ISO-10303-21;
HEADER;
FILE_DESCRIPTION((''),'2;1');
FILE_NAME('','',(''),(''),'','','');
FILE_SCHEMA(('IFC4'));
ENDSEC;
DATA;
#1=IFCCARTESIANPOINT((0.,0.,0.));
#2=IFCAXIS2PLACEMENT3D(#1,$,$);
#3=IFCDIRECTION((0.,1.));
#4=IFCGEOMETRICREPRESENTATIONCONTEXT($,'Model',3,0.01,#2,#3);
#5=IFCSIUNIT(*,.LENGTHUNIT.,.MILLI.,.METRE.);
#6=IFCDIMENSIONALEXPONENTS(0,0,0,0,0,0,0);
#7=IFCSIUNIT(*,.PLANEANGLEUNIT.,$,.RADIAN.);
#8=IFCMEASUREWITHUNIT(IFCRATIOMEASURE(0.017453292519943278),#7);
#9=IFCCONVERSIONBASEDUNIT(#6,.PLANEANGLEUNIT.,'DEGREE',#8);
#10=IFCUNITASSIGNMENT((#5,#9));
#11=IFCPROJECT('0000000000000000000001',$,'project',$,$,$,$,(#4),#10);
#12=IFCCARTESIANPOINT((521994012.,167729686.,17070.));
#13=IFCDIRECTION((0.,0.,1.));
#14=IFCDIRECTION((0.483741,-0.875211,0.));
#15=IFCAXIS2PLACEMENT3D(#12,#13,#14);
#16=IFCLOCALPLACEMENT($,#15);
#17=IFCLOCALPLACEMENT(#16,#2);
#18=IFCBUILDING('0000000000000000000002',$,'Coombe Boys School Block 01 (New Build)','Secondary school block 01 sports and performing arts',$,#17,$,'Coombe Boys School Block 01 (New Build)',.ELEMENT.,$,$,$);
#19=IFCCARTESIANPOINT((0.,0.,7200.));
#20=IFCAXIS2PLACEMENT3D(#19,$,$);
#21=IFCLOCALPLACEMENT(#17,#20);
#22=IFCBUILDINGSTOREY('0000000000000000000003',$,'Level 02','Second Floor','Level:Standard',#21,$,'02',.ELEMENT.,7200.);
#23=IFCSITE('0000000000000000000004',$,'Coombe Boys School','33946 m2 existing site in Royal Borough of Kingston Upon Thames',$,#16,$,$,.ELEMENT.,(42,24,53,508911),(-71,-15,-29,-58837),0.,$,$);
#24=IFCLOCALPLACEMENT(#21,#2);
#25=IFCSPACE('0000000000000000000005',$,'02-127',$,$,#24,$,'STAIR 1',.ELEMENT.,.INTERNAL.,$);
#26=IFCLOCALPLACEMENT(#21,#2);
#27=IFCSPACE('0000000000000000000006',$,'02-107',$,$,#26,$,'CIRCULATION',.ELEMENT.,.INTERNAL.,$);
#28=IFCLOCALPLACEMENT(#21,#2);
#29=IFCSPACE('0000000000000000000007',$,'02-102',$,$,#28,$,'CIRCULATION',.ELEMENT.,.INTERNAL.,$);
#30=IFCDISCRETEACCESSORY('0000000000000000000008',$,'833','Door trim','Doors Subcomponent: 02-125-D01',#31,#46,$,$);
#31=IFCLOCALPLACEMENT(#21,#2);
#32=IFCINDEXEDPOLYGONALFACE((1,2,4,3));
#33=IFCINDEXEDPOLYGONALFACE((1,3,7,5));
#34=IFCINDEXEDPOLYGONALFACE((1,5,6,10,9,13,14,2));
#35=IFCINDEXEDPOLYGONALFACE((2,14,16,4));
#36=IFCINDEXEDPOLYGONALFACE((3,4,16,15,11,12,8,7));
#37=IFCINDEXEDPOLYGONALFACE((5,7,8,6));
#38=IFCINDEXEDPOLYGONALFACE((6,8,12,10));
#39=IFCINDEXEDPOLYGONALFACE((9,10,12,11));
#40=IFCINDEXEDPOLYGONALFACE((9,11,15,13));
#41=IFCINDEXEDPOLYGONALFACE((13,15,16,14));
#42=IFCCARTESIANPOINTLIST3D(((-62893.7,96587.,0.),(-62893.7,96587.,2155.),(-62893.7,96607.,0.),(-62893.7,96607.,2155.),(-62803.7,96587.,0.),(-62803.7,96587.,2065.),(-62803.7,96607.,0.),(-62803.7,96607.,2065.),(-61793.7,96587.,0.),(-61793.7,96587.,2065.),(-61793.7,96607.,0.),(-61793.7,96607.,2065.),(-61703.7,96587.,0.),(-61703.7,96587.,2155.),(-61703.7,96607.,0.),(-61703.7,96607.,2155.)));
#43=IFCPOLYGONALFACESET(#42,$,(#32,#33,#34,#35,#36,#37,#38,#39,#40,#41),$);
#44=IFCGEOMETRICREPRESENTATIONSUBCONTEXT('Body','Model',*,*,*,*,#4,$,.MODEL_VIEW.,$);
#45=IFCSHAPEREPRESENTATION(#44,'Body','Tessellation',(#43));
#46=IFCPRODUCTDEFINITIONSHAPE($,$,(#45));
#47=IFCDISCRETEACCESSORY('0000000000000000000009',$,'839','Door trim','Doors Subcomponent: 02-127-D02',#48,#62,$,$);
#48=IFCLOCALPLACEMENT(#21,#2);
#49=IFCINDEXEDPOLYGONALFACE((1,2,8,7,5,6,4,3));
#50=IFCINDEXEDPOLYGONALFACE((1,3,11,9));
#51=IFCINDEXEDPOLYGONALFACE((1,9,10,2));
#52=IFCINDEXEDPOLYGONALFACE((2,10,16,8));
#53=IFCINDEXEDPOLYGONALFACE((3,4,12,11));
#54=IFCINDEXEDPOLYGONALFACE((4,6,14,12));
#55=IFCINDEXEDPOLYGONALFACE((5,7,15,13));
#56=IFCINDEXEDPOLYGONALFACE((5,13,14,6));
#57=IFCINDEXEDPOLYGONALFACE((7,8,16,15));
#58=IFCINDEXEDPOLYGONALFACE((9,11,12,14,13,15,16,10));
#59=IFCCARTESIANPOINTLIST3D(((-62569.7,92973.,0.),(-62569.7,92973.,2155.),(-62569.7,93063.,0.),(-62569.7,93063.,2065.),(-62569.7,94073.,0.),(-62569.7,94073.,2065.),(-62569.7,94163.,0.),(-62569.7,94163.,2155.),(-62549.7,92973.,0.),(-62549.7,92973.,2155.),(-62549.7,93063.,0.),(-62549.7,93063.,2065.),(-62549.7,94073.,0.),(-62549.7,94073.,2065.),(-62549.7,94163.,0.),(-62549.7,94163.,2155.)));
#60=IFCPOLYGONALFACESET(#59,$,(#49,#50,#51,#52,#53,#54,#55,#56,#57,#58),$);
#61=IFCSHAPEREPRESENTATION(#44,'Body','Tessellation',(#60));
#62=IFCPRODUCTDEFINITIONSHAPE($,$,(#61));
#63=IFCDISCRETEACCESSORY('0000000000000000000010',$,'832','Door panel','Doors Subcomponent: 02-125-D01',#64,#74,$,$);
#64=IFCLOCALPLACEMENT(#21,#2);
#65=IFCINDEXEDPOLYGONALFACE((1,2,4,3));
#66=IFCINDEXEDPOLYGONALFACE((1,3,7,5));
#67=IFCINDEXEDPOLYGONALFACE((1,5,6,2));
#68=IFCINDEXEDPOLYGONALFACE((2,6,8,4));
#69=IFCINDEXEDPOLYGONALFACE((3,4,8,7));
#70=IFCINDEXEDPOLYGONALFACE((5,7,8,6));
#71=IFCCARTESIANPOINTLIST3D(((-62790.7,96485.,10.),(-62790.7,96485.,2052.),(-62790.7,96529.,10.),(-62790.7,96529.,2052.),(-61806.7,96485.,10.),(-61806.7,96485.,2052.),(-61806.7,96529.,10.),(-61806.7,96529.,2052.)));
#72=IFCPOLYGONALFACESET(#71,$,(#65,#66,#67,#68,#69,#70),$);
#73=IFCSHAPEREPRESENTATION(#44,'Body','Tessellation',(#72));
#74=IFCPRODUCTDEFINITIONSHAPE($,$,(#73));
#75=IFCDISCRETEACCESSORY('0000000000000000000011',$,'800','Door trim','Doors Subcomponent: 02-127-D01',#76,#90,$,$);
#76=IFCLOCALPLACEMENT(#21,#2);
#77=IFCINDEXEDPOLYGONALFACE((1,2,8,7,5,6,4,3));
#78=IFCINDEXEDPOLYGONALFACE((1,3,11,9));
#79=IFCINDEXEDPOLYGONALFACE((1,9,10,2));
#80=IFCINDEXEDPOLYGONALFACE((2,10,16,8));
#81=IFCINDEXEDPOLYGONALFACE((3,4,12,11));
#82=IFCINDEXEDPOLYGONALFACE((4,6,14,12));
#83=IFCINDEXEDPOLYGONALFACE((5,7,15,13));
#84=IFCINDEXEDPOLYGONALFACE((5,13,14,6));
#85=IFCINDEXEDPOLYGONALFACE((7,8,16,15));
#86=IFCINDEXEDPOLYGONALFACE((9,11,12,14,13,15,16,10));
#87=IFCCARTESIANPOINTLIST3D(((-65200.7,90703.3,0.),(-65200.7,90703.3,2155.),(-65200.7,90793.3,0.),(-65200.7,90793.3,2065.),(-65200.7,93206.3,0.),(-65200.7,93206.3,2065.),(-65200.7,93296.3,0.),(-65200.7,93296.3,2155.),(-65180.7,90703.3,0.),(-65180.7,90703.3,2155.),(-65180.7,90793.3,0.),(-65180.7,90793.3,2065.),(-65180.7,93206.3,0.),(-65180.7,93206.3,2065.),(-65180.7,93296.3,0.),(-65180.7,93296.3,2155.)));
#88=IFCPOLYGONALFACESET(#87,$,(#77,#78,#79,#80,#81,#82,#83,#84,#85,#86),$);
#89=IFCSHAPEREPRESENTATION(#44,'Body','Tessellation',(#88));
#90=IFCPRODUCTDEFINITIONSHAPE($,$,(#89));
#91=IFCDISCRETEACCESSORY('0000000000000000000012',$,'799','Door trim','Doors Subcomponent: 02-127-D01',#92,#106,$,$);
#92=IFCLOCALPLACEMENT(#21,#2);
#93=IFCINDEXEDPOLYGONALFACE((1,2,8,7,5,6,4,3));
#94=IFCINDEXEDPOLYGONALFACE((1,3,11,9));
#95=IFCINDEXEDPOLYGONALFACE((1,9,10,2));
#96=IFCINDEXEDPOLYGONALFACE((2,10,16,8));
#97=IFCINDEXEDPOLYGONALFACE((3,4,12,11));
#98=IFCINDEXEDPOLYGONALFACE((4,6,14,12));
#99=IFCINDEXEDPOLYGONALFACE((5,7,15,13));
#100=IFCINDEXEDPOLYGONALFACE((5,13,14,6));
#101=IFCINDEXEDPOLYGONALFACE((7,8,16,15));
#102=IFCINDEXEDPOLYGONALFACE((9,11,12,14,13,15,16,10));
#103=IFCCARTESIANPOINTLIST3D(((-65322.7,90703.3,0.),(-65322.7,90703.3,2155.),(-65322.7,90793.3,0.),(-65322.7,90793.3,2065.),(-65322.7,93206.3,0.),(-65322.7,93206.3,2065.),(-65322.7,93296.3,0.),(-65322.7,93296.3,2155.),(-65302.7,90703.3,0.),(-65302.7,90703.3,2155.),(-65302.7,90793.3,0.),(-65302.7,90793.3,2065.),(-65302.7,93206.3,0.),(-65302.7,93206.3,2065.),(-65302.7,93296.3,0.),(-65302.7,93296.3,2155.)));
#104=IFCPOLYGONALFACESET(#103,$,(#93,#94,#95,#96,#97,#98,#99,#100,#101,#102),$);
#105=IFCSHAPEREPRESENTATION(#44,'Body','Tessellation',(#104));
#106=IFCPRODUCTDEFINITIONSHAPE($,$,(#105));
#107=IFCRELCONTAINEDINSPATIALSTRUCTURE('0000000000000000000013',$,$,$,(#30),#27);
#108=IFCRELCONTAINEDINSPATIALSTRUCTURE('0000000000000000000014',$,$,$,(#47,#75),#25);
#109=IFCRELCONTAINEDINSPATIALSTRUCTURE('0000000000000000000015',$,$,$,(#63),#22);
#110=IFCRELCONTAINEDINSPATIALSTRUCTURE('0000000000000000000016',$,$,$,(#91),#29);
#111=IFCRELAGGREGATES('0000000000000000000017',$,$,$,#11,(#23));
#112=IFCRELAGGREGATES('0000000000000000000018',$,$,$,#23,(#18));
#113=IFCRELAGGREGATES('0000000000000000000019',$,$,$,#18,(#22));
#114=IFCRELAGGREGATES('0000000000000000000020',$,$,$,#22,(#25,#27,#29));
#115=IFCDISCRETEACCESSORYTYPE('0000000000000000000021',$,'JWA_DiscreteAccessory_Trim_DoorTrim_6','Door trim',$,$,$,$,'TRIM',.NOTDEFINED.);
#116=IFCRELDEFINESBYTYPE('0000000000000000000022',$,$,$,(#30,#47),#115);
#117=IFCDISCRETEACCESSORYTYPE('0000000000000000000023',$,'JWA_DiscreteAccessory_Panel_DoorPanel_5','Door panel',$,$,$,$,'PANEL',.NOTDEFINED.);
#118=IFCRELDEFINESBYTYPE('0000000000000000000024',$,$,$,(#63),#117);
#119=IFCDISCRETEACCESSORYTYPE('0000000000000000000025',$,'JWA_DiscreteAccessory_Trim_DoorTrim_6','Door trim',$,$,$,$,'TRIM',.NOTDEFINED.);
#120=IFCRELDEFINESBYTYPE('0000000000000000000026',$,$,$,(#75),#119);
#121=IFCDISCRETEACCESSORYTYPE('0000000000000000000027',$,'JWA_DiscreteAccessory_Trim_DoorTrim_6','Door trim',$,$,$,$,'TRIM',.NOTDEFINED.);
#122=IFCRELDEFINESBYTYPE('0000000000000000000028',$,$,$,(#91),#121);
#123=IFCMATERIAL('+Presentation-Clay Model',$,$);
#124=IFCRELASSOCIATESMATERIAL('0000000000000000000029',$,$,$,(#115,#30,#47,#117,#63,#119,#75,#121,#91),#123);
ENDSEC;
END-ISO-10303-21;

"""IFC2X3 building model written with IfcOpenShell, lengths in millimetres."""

from ifc_helpers import new_model, entity, si_unit, converted_unit, direction, frame, origin, origin_2d_with_axis, place, context, subcontext, project, spatial, polyline, rectangle, outline, extrude, source, transform, mapped, material, type_object, type_shapes, element, save


model = new_model("IFC2X3")

# Units and contexts
model_context = context("Model", 3, precision=0.01, world=origin(), true_north=direction((0.0, 1.0)))
body_context = subcontext(model_context, "Body", "Model", "MODEL_VIEW")
ifc_project = project(units=[si_unit("LENGTHUNIT", "METRE", prefix="MILLI"), converted_unit("PLANEANGLEUNIT", "DEGREE", entity("IfcRatioMeasure", 0.017453292519943278), si_unit("PLANEANGLEUNIT", "RADIAN"), dimensions=[0, 0, 0, 0, 0, 0, 0])], contexts=[model_context])

# Site, building, storey
site_placement = place(None, frame((521994012.0, 167729686.0, 17070.0), z_axis=(0.0, 0.0, 1.0), x_axis=(0.483741, -0.875211, 0.0)))
site = spatial("IfcSite", under=ifc_project, at=site_placement, Name="Coombe Boys School", Description="33946 m2 existing site in Royal Borough of Kingston Upon Thames", CompositionType="ELEMENT", RefLatitude=(42, 24, 53, 508911), RefLongitude=(-71, -15, -29, -58837), RefElevation=0.0)
building_placement = place(site_placement, origin())
building = spatial("IfcBuilding", under=site, at=building_placement, Name="Coombe Boys School Block 01 (New Build)", Description="Secondary school block 01 sports and performing arts", LongName="Coombe Boys School Block 01 (New Build)", CompositionType="ELEMENT")
storey_placement = place(building_placement, frame((0.0, 0.0, 7200.0)))
storey = spatial("IfcBuildingStorey", under=building, at=storey_placement, Name="Level 02", Description="Second Floor", ObjectType="Level:Standard", LongName="02", CompositionType="ELEMENT", Elevation=7200.0)

# Shared definitions
ifc_material_1 = material(Name="+Presentation-Clay Model")

# Shared definitions
space_1_placement = place(storey_placement, origin())
space_1 = spatial("IfcSpace", under=storey, at=space_1_placement, Name="02-127", LongName="STAIR 1", CompositionType="ELEMENT", InteriorOrExteriorSpace="INTERNAL")

# Shared definitions
space_2_placement = place(storey_placement, origin())
space_2 = spatial("IfcSpace", under=storey, at=space_2_placement, Name="02-107", LongName="CIRCULATION", CompositionType="ELEMENT", InteriorOrExteriorSpace="INTERNAL")

# Discrete accessories
discrete_accessory_type_1 = type_object("IfcDiscreteAccessoryType", Name="JWA_DiscreteAccessory_Trim_DoorTrim_6", Description="Door trim", ElementType="TRIM", material=ifc_material_1)
shared_shape_1 = source(origin(), body_context, "Body", "SweptSolid", [
    extrude(outline(polyline([(505.0, -1055.0), (595.0, -1055.0), (595.0, 1100.0), (-595.0, 1100.0), (-595.0, -1055.0), (-505.0, -1055.0), (-505.0, 1010.0), (505.0, 1010.0), (505.0, -1055.0)])), frame((0.0, 0.0, 1055.0), z_axis=(0.0, 1.0, 0.0), x_axis=(-1.0, 0.0, 0.0)), (0.0, 0.0, 1.0), 20.0),
])
type_shapes(discrete_accessory_type_1, [shared_shape_1])
discrete_accessory_1_placement = place(space_2_placement, frame((-62298.7, 96587.0, 0.0)))
element("IfcDiscreteAccessory", 1, at=discrete_accessory_1_placement, inside=space_2, type_object=discrete_accessory_type_1, material=ifc_material_1, Name="833", Description="Door trim", ObjectType="Doors Subcomponent: 02-125-D01", context=body_context, shape_type="MappedRepresentation", body=[
    mapped(shared_shape_1, transform((0.0, 0.0, 0.0), scale=1.0)),
])
discrete_accessory_2_placement = place(space_1_placement, frame((-62549.7, 93568.0, 0.0), z_axis=(0.0, 0.0, 1.0), x_axis=(0.0, 1.0, 0.0)))
element("IfcDiscreteAccessory", 2, at=discrete_accessory_2_placement, inside=space_1, type_object=discrete_accessory_type_1, material=ifc_material_1, Name="839", Description="Door trim", ObjectType="Doors Subcomponent: 02-127-D02", context=body_context, shape_type="MappedRepresentation", body=[
    mapped(shared_shape_1, transform((0.0, 0.0, 0.0), scale=1.0)),
])
discrete_accessory_type_2 = type_object("IfcDiscreteAccessoryType", Name="JWA_DiscreteAccessory_Panel_DoorPanel_5", Description="Door panel", ElementType="PANEL", material=ifc_material_1)
shared_shape_2 = source(origin(), body_context, "Body", "SweptSolid", [
    extrude(rectangle(XDim=984.0, YDim=44.0, at=origin_2d_with_axis()), frame((0.0, -22.0, 10.0)), (0.0, 0.0, 1.0), 2042.0),
])
type_shapes(discrete_accessory_type_2, [shared_shape_2])
discrete_accessory_3_placement = place(storey_placement, frame((-62298.7, 96529.0, 0.0)))
element("IfcDiscreteAccessory", 3, at=discrete_accessory_3_placement, inside=storey, type_object=discrete_accessory_type_2, material=ifc_material_1, Name="832", Description="Door panel", ObjectType="Doors Subcomponent: 02-125-D01", context=body_context, shape_type="MappedRepresentation", body=[
    mapped(shared_shape_2, transform((0.0, 0.0, 0.0), scale=1.0)),
])
discrete_accessory_type_3 = type_object("IfcDiscreteAccessoryType", Name="JWA_DiscreteAccessory_Trim_DoorTrim_6", Description="Door trim", ElementType="TRIM", material=ifc_material_1)
shared_shape_3 = source(origin(), body_context, "Body", "SweptSolid", [
    extrude(outline(polyline([(1206.5, -1055.0), (1296.5, -1055.0), (1296.5, 1100.0), (-1296.5, 1100.0), (-1296.5, -1055.0), (-1206.5, -1055.0), (-1206.5, 1010.0), (1206.5, 1010.0), (1206.5, -1055.0)])), frame((0.0, 0.0, 1055.0), z_axis=(0.0, 1.0, 0.0), x_axis=(-1.0, 0.0, 0.0)), (0.0, 0.0, 1.0), 20.0),
])
type_shapes(discrete_accessory_type_3, [shared_shape_3])
discrete_accessory_4_placement = place(space_1_placement, frame((-65200.7, 91999.8, 0.0), z_axis=(0.0, 0.0, 1.0), x_axis=(0.0, -1.0, 0.0)))
element("IfcDiscreteAccessory", 4, at=discrete_accessory_4_placement, inside=space_1, type_object=discrete_accessory_type_3, material=ifc_material_1, Name="800", Description="Door trim", ObjectType="Doors Subcomponent: 02-127-D01", context=body_context, shape_type="MappedRepresentation", body=[
    mapped(shared_shape_3, transform((0.0, 0.0, 0.0), scale=1.0)),
])

# Shared definitions
space_3_placement = place(storey_placement, origin())
space_3 = spatial("IfcSpace", under=storey, at=space_3_placement, Name="02-102", LongName="CIRCULATION", CompositionType="ELEMENT", InteriorOrExteriorSpace="INTERNAL")

# Discrete accessory
discrete_accessory_type_4 = type_object("IfcDiscreteAccessoryType", Name="JWA_DiscreteAccessory_Trim_DoorTrim_6", Description="Door trim", ElementType="TRIM", material=ifc_material_1)
shared_shape_4 = source(origin(), body_context, "Body", "SweptSolid", [
    extrude(outline(polyline([(-1055.0, -1296.5), (1100.0, -1296.5), (1100.0, 1296.5), (-1055.0, 1296.5), (-1055.0, 1206.5), (1010.0, 1206.5), (1010.0, -1206.5), (-1055.0, -1206.5), (-1055.0, -1296.5)])), frame((0.0, -20.0, 1055.0), z_axis=(0.0, 1.0, 0.0), x_axis=(0.0, 0.0, 1.0)), (0.0, 0.0, 1.0), 20.0),
])
type_shapes(discrete_accessory_type_4, [shared_shape_4])
discrete_accessory_5_placement = place(space_3_placement, frame((-65302.7, 91999.8, 0.0), z_axis=(0.0, 0.0, 1.0), x_axis=(0.0, -1.0, 0.0)))
element("IfcDiscreteAccessory", 5, at=discrete_accessory_5_placement, inside=space_3, type_object=discrete_accessory_type_4, material=ifc_material_1, Name="799", Description="Door trim", ObjectType="Doors Subcomponent: 02-127-D01", context=body_context, shape_type="MappedRepresentation", body=[
    mapped(shared_shape_4, transform((0.0, 0.0, 0.0), scale=1.0)),
])

save(model, "model.ifc")
